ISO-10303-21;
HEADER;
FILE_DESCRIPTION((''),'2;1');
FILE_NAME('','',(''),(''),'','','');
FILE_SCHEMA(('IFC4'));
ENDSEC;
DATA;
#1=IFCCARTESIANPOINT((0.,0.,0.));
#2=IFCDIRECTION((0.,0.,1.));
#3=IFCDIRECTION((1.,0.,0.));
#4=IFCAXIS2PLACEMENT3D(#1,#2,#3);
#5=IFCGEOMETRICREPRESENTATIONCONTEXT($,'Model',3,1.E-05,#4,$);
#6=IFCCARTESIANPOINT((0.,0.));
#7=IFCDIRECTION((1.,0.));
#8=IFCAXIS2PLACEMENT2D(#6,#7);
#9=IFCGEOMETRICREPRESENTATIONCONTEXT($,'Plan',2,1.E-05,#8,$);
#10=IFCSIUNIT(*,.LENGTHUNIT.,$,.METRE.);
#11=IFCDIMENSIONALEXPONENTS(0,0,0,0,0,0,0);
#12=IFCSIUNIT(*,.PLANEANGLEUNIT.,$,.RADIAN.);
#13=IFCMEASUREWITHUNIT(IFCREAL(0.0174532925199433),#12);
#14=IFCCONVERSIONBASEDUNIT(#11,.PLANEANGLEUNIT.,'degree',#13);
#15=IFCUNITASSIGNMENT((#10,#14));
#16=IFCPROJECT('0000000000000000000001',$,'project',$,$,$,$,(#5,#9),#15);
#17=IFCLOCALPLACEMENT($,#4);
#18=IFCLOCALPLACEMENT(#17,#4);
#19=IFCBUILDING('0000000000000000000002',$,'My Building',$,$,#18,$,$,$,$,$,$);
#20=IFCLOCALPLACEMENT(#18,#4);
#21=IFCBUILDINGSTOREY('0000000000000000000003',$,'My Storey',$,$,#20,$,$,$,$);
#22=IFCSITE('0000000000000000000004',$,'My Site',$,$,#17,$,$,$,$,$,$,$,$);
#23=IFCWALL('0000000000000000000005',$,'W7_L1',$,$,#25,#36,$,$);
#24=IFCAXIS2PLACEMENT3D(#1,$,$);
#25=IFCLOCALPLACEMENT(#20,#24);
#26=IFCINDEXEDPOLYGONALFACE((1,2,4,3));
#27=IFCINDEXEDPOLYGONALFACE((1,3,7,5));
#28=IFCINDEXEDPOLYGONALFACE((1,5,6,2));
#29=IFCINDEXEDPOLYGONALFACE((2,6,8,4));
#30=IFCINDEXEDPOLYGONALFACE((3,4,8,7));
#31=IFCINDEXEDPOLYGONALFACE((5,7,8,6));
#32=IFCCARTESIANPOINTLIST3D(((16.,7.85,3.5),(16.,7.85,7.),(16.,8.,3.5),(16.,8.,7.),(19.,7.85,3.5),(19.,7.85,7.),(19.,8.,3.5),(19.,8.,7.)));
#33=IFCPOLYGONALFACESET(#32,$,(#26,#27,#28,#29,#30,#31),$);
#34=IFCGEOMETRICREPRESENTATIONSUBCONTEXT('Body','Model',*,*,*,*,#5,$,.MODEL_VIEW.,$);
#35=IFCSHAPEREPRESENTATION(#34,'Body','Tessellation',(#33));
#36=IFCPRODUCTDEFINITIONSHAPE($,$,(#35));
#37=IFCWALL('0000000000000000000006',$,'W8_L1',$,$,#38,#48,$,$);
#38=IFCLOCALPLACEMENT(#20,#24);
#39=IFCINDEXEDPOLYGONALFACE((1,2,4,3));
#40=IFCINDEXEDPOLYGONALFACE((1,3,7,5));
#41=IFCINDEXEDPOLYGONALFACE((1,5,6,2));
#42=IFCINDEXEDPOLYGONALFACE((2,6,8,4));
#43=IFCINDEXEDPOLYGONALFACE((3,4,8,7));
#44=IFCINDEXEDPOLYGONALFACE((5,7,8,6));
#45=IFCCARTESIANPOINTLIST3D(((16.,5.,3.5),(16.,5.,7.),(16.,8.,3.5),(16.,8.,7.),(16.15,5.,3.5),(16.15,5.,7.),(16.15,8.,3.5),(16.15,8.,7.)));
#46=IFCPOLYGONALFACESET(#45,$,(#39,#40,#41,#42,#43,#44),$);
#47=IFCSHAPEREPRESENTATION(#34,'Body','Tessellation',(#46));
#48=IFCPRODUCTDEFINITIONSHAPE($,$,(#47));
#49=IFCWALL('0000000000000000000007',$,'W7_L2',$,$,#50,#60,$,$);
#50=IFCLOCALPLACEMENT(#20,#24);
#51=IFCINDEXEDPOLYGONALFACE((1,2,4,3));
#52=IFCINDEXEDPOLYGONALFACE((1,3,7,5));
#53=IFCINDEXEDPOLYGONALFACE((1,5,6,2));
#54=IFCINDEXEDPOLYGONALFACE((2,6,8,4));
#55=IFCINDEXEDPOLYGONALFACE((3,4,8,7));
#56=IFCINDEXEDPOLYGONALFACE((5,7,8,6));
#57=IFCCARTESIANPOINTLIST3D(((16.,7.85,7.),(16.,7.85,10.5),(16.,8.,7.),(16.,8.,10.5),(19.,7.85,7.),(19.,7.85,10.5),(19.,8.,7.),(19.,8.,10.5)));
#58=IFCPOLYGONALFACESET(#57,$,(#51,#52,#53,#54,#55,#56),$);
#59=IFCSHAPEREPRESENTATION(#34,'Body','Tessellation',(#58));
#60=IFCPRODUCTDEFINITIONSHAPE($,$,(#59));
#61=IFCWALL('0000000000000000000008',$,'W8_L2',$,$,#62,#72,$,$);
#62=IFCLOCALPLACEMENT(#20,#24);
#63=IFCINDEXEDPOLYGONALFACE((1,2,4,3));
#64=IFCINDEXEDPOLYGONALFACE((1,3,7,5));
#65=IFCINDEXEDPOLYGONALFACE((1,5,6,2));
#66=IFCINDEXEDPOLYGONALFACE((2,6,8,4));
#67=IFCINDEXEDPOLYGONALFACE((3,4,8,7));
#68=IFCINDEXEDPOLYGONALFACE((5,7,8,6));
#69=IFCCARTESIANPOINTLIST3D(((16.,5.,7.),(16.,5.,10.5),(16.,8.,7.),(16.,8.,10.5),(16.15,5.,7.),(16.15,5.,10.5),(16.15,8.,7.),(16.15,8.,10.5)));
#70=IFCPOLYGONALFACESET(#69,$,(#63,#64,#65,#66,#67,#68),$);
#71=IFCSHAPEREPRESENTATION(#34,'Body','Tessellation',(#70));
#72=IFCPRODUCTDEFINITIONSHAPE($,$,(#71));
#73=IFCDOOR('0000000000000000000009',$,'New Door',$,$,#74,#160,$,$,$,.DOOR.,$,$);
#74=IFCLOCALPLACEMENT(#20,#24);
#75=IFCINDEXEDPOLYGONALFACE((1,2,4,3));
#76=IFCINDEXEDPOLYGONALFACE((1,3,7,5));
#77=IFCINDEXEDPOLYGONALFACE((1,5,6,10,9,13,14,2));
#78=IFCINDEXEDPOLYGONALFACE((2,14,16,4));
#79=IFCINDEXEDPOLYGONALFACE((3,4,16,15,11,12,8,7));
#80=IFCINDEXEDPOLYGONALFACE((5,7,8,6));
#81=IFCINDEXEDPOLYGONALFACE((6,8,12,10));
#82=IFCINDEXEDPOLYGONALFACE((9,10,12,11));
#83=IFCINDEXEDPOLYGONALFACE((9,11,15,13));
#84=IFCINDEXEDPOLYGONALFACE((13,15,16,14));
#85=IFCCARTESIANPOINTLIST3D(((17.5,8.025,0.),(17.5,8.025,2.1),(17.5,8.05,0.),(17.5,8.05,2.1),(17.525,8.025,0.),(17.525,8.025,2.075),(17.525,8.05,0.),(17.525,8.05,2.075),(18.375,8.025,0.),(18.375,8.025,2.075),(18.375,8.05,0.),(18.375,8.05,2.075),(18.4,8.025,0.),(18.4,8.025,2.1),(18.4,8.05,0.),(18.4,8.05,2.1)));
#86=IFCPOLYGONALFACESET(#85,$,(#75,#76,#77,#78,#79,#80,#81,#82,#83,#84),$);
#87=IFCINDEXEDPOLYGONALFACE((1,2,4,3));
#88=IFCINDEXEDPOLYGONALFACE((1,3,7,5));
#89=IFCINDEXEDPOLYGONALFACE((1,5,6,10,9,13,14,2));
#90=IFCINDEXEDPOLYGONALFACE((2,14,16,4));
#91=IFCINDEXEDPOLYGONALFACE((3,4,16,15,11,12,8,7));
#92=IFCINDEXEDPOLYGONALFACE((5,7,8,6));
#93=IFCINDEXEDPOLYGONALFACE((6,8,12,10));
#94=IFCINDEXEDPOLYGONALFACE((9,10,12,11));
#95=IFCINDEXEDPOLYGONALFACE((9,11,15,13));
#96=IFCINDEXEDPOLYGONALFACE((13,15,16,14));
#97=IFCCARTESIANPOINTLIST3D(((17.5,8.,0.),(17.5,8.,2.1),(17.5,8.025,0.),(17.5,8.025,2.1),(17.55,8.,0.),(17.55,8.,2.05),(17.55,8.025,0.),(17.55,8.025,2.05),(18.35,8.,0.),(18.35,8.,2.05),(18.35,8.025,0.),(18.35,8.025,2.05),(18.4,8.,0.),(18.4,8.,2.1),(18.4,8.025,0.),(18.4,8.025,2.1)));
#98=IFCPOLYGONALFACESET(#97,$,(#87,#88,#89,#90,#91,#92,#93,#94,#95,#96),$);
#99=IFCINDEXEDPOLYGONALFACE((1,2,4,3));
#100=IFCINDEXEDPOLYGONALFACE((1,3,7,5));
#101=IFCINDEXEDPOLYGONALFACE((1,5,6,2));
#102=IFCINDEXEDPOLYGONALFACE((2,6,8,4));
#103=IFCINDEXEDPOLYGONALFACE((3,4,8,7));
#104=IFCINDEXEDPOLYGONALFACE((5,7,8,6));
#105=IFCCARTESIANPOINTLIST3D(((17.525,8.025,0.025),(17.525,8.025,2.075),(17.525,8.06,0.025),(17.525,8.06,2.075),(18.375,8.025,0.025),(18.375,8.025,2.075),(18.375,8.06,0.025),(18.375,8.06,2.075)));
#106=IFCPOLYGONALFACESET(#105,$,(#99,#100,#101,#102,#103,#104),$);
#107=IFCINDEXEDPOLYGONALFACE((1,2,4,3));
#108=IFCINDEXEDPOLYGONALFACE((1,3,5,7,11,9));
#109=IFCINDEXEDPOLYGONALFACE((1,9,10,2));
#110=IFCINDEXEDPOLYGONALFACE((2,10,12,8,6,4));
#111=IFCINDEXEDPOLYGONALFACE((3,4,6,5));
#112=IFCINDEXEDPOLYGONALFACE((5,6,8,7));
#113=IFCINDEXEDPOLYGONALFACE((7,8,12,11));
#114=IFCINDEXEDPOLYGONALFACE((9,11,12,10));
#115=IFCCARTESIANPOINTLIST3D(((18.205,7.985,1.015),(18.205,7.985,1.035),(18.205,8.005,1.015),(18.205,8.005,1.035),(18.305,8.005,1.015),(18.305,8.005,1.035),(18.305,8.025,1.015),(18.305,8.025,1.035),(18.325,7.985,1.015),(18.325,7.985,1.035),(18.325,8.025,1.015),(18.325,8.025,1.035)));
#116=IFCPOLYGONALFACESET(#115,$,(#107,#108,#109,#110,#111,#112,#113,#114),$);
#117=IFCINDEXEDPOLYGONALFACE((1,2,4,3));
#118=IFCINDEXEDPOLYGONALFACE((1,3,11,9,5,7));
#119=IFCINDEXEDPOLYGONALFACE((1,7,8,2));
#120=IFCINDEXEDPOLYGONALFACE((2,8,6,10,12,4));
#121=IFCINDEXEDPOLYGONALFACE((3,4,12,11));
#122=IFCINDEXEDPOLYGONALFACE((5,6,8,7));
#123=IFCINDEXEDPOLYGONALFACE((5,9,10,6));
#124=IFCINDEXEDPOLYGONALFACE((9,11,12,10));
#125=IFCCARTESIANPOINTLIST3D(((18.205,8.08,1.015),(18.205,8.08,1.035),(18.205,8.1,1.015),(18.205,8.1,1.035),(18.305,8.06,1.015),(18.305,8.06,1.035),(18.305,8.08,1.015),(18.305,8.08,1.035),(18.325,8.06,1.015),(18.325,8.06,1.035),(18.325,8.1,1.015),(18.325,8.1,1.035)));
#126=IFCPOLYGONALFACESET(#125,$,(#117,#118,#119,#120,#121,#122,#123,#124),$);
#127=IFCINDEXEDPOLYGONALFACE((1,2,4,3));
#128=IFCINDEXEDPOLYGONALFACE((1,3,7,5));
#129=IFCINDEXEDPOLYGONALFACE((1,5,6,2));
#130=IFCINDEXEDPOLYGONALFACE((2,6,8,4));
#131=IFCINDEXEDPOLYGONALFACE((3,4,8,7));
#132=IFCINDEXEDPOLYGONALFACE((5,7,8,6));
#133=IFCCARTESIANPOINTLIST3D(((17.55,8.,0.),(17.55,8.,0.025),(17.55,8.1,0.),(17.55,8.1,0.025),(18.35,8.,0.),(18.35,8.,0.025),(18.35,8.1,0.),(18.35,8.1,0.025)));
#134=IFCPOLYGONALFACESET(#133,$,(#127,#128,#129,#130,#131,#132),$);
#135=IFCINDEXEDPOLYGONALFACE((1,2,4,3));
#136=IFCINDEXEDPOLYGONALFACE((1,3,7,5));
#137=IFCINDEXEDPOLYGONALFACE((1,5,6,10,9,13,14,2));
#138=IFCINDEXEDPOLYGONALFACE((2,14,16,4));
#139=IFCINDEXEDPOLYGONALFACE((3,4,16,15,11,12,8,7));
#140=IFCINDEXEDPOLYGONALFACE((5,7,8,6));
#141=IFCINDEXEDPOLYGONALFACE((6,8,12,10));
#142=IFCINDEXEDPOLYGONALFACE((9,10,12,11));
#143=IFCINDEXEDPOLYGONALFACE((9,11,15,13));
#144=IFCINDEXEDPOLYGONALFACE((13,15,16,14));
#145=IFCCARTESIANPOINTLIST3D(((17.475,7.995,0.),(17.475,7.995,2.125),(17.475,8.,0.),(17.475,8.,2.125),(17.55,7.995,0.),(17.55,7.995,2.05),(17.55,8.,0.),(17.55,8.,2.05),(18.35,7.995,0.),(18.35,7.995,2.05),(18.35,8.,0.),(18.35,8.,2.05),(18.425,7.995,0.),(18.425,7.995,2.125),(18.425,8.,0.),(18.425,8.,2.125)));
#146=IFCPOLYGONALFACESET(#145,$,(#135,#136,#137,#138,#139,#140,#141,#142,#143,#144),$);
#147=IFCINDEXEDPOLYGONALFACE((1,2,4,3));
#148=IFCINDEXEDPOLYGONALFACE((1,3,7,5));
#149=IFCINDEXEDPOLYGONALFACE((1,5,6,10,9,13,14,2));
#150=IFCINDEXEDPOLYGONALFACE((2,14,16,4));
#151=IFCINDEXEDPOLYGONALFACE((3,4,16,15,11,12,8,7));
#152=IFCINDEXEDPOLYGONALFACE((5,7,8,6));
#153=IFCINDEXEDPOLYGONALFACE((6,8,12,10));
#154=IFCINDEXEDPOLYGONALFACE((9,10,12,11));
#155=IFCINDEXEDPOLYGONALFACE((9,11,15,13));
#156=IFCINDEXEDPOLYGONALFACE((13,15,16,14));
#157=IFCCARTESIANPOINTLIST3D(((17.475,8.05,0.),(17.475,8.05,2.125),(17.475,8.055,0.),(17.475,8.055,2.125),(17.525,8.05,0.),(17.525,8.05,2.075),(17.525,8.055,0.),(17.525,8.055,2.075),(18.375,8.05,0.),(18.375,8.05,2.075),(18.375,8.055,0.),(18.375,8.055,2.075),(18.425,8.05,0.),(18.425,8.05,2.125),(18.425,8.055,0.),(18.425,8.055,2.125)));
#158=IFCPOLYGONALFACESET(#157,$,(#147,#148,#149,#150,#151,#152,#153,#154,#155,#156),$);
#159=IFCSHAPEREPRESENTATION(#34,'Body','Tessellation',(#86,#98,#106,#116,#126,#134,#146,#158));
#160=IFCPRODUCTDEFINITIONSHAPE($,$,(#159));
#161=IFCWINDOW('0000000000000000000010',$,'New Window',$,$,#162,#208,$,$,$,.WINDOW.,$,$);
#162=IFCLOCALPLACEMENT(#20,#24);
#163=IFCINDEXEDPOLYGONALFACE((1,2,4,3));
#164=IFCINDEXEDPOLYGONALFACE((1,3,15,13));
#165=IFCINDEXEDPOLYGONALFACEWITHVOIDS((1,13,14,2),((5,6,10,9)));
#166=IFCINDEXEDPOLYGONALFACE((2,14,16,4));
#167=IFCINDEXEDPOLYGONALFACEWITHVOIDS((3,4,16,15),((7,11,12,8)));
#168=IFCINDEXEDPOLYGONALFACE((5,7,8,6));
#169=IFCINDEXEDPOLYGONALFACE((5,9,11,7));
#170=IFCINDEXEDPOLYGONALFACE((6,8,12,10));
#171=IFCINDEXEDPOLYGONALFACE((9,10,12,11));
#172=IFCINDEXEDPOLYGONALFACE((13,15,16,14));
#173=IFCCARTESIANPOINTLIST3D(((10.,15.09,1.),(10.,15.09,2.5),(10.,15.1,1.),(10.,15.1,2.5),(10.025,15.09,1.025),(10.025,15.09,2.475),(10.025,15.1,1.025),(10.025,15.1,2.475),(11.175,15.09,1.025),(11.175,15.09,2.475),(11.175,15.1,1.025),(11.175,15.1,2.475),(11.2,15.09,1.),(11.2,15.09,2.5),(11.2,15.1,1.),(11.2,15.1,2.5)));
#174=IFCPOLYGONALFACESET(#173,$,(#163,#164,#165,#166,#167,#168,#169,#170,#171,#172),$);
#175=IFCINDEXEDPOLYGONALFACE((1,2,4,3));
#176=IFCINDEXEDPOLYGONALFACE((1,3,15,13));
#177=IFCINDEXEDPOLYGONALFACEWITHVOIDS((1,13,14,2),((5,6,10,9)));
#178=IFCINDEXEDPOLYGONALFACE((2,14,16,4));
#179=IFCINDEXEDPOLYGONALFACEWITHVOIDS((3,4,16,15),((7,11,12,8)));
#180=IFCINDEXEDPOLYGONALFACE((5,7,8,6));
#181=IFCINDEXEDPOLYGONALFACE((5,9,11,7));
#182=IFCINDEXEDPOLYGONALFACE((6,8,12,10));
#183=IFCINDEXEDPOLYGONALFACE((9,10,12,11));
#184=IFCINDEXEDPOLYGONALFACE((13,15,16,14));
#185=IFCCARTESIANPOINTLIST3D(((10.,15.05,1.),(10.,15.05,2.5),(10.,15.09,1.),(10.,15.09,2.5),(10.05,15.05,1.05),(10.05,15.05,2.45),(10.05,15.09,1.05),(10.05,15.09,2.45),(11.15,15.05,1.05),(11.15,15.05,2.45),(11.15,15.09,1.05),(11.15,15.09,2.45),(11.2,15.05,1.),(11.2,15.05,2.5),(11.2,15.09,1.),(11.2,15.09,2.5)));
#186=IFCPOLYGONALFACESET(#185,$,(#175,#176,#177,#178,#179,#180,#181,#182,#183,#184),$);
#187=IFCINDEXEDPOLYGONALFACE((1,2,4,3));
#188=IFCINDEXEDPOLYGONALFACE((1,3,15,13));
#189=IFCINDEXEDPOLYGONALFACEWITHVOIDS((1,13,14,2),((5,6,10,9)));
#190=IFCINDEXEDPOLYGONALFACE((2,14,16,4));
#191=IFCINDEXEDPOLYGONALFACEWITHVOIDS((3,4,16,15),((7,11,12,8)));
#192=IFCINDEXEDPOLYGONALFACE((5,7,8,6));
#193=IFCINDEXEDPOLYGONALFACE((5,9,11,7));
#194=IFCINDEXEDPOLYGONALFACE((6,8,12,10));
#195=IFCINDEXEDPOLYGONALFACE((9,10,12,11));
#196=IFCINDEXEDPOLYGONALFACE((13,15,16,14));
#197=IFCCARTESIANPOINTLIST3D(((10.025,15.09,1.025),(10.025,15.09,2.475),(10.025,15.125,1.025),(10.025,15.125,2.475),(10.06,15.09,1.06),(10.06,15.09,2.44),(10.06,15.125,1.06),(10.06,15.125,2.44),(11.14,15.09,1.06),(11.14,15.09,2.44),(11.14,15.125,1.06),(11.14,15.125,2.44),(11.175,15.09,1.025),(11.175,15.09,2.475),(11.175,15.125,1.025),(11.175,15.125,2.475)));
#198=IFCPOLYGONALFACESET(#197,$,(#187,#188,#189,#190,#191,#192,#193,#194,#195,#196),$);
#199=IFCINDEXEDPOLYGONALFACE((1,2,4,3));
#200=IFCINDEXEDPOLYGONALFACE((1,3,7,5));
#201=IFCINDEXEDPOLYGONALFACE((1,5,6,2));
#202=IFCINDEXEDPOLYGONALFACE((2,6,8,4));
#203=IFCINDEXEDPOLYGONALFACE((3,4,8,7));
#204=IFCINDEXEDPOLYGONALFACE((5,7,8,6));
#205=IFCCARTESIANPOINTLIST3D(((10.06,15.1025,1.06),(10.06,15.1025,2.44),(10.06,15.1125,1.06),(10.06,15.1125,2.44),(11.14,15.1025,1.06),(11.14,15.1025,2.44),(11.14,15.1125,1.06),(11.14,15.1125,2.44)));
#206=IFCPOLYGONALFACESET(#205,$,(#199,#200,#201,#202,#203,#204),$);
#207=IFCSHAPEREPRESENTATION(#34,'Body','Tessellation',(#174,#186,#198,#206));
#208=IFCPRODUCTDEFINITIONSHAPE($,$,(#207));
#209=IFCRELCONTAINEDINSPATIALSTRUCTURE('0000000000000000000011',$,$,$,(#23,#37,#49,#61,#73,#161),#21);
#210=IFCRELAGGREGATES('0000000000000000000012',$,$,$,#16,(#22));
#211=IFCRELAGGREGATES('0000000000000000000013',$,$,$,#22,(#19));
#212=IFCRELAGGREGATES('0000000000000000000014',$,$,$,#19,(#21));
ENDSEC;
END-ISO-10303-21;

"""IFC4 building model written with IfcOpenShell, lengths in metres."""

from ifc_helpers import new_model, entity, si_unit, converted_unit, frame, origin_with_axes, origin_2d_with_axis, place, context, subcontext, project, spatial, line, indexed_curve, outline, extrude, element, save


model = new_model("IFC4")

# Units and contexts
model_context = context("Model", 3, precision=1e-05, world=origin_with_axes())
plan_context = context("Plan", 2, precision=1e-05, world=origin_2d_with_axis())
body_context = subcontext(model_context, "Body", "Model", "MODEL_VIEW")
ifc_project = project(units=[si_unit("LENGTHUNIT", "METRE"), converted_unit("PLANEANGLEUNIT", "degree", entity("IfcReal", 0.0174532925199433), si_unit("PLANEANGLEUNIT", "RADIAN"), dimensions=[0, 0, 0, 0, 0, 0, 0])], contexts=[model_context, plan_context])

# Site, building, storey
site_placement = place(None, origin_with_axes())
site = spatial("IfcSite", under=ifc_project, at=site_placement, Name="My Site")
building_placement = place(site_placement, origin_with_axes())
building = spatial("IfcBuilding", under=site, at=building_placement, Name="My Building")
storey_placement = place(building_placement, origin_with_axes())
storey = spatial("IfcBuildingStorey", under=building, at=storey_placement, Name="My Storey")

# Walls
for number, where, z_axis, x_axis, name in (
    (1, (19.0, 8.0, 3.5), (0.0, 0.0, 1.0), (-1.0, 0.0, 0.0), "W7_L1"),
    (2, (16.0, 8.0, 3.5), (0.0, 0.0, 1.0), (0.0, -1.0, 0.0), "W8_L1"),
    (3, (19.0, 8.0, 7.0), (0.0, 0.0, 1.0), (-1.0, 0.0, 0.0), "W7_L2"),
    (4, (16.0, 8.0, 7.0), (0.0, 0.0, 1.0), (0.0, -1.0, 0.0), "W8_L2"),
):
    element("IfcWall", number, at=place(storey_placement, frame(where, z_axis=z_axis, x_axis=x_axis)), inside=storey, Name=name, context=body_context, shape_type="SweptSolid", body=[
        extrude(outline(indexed_curve([(0.0, 0.0), (0.0, 0.15), (3.0, 0.15), (3.0, 0.0), (0.0, 0.0)], self_intersect=False)), origin_with_axes(), (0.0, 0.0, 1.0), 3.5),
    ])

# Door
door_placement = place(storey_placement, frame((17.5, 8.0, 0.0), z_axis=(0.0, 0.0, 1.0), x_axis=(1.0, 0.0, 0.0)))
element("IfcDoor", 5, at=door_placement, inside=storey, Name="New Door", PredefinedType="DOOR", context=body_context, shape_type="SweptSolid", body=[
    extrude(outline(indexed_curve([(0.0, 0.0), (0.0, 2.1), (0.9, 2.1), (0.9, 0.0), (0.875, 0.0), (0.875, 2.075), (0.025, 2.075), (0.025, 0.0)], segments=[line(1, 2, 3, 4, 5, 6, 7, 8, 1)])), frame((0.0, 0.025, 0.0), z_axis=(0.0, -1.0, 0.0), x_axis=(1.0, 0.0, 0.0)), (0.0, 0.0, -1.0), 0.025),
    extrude(outline(indexed_curve([(0.0, 0.0), (0.0, 2.1), (0.9, 2.1), (0.9, 0.0), (0.85, 0.0), (0.85, 2.05), (0.05, 2.05), (0.05, 0.0)], segments=[line(1, 2, 3, 4, 5, 6, 7, 8, 1)])), frame((0.0, 0.0, 0.0), z_axis=(0.0, -1.0, 0.0), x_axis=(1.0, 0.0, 0.0)), (0.0, 0.0, -1.0), 0.025),
    extrude(outline(indexed_curve([(0.0, 0.0), (0.85, 0.0), (0.85, 0.035), (0.0, 0.035)], segments=[line(1, 2, 3, 4, 1)])), frame((0.025, 0.025, 0.025), z_axis=(0.0, 0.0, 1.0), x_axis=(1.0, 0.0, 0.0)), (0.0, 0.0, 1.0), 2.05),
    extrude(outline(indexed_curve([(0.0, 0.0), (0.0, -0.04), (-0.12, -0.04), (-0.12, -0.02), (-0.02, -0.02), (-0.02, 0.0)], segments=[line(1, 2, 3, 4, 5, 6, 1)])), frame((0.825, 0.025, 1.015), z_axis=(0.0, 0.0, 1.0), x_axis=(1.0, 0.0, 0.0)), (0.0, 0.0, 1.0), 0.02),
    extrude(outline(indexed_curve([(0.0, 0.0), (0.0, 0.04), (-0.12, 0.04), (-0.12, 0.02), (-0.02, 0.02), (-0.02, 0.0)], segments=[line(1, 2, 3, 4, 5, 6, 1)])), frame((0.825, 0.06, 1.015), z_axis=(0.0, 0.0, 1.0), x_axis=(1.0, 0.0, 0.0)), (0.0, 0.0, 1.0), 0.02),
    extrude(outline(indexed_curve([(0.0, 0.0), (0.8, 0.0), (0.8, 0.1), (0.0, 0.1)], segments=[line(1, 2, 3, 4, 1)])), frame((0.05, 0.0, 0.0), z_axis=(0.0, 0.0, 1.0), x_axis=(1.0, 0.0, 0.0)), (0.0, 0.0, 1.0), 0.025),
    extrude(outline(indexed_curve([(0.0, 0.0), (0.0, 2.125), (0.95, 2.125), (0.95, 0.0), (0.875, 0.0), (0.875, 2.05), (0.075, 2.05), (0.075, 0.0)], segments=[line(1, 2, 3, 4, 5, 6, 7, 8, 1)])), frame((-0.025, -0.005, 0.0), z_axis=(0.0, -1.0, 0.0), x_axis=(1.0, 0.0, 0.0)), (0.0, 0.0, -1.0), 0.005),
    extrude(outline(indexed_curve([(0.0, 0.0), (0.0, 2.125), (0.95, 2.125), (0.95, 0.0), (0.9, 0.0), (0.9, 2.075), (0.05, 2.075), (0.05, 0.0)], segments=[line(1, 2, 3, 4, 5, 6, 7, 8, 1)])), frame((-0.025, 0.05, 0.0), z_axis=(0.0, -1.0, 0.0), x_axis=(1.0, 0.0, 0.0)), (0.0, 0.0, -1.0), 0.005),
])

# Window
for number, where, z_axis, x_axis, name in (
    (6, (10.0, 15.0, 1.0), (0.0, 0.0, 1.0), (1.0, 0.0, 0.0), "New Window"),
):
    element("IfcWindow", number, at=place(storey_placement, frame(where, z_axis=z_axis, x_axis=x_axis)), inside=storey, Name=name, PredefinedType="WINDOW", context=body_context, shape_type="SweptSolid", body=[
        extrude(outline(indexed_curve([(0.0, 0.0), (1.2, 0.0), (1.2, 1.5), (0.0, 1.5)], segments=[line(1, 2, 3, 4, 1)]), holes=[indexed_curve([(0.025, 0.025), (1.175, 0.025), (1.175, 1.475), (0.025, 1.475)], segments=[line(1, 2, 3, 4, 1)])]), frame((0.0, 0.09, 0.0), z_axis=(0.0, -1.0, 0.0), x_axis=(1.0, 0.0, 0.0)), (0.0, 0.0, -1.0), 0.01),
        extrude(outline(indexed_curve([(0.0, 0.0), (1.2, 0.0), (1.2, 1.5), (0.0, 1.5)], segments=[line(1, 2, 3, 4, 1)]), holes=[indexed_curve([(0.05, 0.05), (1.15, 0.05), (1.15, 1.45), (0.05, 1.45)], segments=[line(1, 2, 3, 4, 1)])]), frame((0.0, 0.05, 0.0), z_axis=(0.0, -1.0, 0.0), x_axis=(1.0, 0.0, 0.0)), (0.0, 0.0, -1.0), 0.04),
        extrude(outline(indexed_curve([(0.0, 0.0), (1.15, 0.0), (1.15, 1.45), (0.0, 1.45)], segments=[line(1, 2, 3, 4, 1)]), holes=[indexed_curve([(0.035, 0.035), (1.115, 0.035), (1.115, 1.415), (0.035, 1.415)], segments=[line(1, 2, 3, 4, 1)])]), frame((0.025, 0.09, 0.025), z_axis=(0.0, -1.0, 0.0), x_axis=(1.0, 0.0, 0.0)), (0.0, 0.0, -1.0), 0.035),
        extrude(outline(indexed_curve([(0.035, 0.035), (1.115, 0.035), (1.115, 1.415), (0.035, 1.415)], segments=[line(1, 2, 3, 4, 1)])), frame((0.025, 0.1025, 0.025), z_axis=(0.0, -1.0, 0.0), x_axis=(1.0, 0.0, 0.0)), (0.0, 0.0, -1.0), 0.01),
    ])

save(model, "model.ifc")
